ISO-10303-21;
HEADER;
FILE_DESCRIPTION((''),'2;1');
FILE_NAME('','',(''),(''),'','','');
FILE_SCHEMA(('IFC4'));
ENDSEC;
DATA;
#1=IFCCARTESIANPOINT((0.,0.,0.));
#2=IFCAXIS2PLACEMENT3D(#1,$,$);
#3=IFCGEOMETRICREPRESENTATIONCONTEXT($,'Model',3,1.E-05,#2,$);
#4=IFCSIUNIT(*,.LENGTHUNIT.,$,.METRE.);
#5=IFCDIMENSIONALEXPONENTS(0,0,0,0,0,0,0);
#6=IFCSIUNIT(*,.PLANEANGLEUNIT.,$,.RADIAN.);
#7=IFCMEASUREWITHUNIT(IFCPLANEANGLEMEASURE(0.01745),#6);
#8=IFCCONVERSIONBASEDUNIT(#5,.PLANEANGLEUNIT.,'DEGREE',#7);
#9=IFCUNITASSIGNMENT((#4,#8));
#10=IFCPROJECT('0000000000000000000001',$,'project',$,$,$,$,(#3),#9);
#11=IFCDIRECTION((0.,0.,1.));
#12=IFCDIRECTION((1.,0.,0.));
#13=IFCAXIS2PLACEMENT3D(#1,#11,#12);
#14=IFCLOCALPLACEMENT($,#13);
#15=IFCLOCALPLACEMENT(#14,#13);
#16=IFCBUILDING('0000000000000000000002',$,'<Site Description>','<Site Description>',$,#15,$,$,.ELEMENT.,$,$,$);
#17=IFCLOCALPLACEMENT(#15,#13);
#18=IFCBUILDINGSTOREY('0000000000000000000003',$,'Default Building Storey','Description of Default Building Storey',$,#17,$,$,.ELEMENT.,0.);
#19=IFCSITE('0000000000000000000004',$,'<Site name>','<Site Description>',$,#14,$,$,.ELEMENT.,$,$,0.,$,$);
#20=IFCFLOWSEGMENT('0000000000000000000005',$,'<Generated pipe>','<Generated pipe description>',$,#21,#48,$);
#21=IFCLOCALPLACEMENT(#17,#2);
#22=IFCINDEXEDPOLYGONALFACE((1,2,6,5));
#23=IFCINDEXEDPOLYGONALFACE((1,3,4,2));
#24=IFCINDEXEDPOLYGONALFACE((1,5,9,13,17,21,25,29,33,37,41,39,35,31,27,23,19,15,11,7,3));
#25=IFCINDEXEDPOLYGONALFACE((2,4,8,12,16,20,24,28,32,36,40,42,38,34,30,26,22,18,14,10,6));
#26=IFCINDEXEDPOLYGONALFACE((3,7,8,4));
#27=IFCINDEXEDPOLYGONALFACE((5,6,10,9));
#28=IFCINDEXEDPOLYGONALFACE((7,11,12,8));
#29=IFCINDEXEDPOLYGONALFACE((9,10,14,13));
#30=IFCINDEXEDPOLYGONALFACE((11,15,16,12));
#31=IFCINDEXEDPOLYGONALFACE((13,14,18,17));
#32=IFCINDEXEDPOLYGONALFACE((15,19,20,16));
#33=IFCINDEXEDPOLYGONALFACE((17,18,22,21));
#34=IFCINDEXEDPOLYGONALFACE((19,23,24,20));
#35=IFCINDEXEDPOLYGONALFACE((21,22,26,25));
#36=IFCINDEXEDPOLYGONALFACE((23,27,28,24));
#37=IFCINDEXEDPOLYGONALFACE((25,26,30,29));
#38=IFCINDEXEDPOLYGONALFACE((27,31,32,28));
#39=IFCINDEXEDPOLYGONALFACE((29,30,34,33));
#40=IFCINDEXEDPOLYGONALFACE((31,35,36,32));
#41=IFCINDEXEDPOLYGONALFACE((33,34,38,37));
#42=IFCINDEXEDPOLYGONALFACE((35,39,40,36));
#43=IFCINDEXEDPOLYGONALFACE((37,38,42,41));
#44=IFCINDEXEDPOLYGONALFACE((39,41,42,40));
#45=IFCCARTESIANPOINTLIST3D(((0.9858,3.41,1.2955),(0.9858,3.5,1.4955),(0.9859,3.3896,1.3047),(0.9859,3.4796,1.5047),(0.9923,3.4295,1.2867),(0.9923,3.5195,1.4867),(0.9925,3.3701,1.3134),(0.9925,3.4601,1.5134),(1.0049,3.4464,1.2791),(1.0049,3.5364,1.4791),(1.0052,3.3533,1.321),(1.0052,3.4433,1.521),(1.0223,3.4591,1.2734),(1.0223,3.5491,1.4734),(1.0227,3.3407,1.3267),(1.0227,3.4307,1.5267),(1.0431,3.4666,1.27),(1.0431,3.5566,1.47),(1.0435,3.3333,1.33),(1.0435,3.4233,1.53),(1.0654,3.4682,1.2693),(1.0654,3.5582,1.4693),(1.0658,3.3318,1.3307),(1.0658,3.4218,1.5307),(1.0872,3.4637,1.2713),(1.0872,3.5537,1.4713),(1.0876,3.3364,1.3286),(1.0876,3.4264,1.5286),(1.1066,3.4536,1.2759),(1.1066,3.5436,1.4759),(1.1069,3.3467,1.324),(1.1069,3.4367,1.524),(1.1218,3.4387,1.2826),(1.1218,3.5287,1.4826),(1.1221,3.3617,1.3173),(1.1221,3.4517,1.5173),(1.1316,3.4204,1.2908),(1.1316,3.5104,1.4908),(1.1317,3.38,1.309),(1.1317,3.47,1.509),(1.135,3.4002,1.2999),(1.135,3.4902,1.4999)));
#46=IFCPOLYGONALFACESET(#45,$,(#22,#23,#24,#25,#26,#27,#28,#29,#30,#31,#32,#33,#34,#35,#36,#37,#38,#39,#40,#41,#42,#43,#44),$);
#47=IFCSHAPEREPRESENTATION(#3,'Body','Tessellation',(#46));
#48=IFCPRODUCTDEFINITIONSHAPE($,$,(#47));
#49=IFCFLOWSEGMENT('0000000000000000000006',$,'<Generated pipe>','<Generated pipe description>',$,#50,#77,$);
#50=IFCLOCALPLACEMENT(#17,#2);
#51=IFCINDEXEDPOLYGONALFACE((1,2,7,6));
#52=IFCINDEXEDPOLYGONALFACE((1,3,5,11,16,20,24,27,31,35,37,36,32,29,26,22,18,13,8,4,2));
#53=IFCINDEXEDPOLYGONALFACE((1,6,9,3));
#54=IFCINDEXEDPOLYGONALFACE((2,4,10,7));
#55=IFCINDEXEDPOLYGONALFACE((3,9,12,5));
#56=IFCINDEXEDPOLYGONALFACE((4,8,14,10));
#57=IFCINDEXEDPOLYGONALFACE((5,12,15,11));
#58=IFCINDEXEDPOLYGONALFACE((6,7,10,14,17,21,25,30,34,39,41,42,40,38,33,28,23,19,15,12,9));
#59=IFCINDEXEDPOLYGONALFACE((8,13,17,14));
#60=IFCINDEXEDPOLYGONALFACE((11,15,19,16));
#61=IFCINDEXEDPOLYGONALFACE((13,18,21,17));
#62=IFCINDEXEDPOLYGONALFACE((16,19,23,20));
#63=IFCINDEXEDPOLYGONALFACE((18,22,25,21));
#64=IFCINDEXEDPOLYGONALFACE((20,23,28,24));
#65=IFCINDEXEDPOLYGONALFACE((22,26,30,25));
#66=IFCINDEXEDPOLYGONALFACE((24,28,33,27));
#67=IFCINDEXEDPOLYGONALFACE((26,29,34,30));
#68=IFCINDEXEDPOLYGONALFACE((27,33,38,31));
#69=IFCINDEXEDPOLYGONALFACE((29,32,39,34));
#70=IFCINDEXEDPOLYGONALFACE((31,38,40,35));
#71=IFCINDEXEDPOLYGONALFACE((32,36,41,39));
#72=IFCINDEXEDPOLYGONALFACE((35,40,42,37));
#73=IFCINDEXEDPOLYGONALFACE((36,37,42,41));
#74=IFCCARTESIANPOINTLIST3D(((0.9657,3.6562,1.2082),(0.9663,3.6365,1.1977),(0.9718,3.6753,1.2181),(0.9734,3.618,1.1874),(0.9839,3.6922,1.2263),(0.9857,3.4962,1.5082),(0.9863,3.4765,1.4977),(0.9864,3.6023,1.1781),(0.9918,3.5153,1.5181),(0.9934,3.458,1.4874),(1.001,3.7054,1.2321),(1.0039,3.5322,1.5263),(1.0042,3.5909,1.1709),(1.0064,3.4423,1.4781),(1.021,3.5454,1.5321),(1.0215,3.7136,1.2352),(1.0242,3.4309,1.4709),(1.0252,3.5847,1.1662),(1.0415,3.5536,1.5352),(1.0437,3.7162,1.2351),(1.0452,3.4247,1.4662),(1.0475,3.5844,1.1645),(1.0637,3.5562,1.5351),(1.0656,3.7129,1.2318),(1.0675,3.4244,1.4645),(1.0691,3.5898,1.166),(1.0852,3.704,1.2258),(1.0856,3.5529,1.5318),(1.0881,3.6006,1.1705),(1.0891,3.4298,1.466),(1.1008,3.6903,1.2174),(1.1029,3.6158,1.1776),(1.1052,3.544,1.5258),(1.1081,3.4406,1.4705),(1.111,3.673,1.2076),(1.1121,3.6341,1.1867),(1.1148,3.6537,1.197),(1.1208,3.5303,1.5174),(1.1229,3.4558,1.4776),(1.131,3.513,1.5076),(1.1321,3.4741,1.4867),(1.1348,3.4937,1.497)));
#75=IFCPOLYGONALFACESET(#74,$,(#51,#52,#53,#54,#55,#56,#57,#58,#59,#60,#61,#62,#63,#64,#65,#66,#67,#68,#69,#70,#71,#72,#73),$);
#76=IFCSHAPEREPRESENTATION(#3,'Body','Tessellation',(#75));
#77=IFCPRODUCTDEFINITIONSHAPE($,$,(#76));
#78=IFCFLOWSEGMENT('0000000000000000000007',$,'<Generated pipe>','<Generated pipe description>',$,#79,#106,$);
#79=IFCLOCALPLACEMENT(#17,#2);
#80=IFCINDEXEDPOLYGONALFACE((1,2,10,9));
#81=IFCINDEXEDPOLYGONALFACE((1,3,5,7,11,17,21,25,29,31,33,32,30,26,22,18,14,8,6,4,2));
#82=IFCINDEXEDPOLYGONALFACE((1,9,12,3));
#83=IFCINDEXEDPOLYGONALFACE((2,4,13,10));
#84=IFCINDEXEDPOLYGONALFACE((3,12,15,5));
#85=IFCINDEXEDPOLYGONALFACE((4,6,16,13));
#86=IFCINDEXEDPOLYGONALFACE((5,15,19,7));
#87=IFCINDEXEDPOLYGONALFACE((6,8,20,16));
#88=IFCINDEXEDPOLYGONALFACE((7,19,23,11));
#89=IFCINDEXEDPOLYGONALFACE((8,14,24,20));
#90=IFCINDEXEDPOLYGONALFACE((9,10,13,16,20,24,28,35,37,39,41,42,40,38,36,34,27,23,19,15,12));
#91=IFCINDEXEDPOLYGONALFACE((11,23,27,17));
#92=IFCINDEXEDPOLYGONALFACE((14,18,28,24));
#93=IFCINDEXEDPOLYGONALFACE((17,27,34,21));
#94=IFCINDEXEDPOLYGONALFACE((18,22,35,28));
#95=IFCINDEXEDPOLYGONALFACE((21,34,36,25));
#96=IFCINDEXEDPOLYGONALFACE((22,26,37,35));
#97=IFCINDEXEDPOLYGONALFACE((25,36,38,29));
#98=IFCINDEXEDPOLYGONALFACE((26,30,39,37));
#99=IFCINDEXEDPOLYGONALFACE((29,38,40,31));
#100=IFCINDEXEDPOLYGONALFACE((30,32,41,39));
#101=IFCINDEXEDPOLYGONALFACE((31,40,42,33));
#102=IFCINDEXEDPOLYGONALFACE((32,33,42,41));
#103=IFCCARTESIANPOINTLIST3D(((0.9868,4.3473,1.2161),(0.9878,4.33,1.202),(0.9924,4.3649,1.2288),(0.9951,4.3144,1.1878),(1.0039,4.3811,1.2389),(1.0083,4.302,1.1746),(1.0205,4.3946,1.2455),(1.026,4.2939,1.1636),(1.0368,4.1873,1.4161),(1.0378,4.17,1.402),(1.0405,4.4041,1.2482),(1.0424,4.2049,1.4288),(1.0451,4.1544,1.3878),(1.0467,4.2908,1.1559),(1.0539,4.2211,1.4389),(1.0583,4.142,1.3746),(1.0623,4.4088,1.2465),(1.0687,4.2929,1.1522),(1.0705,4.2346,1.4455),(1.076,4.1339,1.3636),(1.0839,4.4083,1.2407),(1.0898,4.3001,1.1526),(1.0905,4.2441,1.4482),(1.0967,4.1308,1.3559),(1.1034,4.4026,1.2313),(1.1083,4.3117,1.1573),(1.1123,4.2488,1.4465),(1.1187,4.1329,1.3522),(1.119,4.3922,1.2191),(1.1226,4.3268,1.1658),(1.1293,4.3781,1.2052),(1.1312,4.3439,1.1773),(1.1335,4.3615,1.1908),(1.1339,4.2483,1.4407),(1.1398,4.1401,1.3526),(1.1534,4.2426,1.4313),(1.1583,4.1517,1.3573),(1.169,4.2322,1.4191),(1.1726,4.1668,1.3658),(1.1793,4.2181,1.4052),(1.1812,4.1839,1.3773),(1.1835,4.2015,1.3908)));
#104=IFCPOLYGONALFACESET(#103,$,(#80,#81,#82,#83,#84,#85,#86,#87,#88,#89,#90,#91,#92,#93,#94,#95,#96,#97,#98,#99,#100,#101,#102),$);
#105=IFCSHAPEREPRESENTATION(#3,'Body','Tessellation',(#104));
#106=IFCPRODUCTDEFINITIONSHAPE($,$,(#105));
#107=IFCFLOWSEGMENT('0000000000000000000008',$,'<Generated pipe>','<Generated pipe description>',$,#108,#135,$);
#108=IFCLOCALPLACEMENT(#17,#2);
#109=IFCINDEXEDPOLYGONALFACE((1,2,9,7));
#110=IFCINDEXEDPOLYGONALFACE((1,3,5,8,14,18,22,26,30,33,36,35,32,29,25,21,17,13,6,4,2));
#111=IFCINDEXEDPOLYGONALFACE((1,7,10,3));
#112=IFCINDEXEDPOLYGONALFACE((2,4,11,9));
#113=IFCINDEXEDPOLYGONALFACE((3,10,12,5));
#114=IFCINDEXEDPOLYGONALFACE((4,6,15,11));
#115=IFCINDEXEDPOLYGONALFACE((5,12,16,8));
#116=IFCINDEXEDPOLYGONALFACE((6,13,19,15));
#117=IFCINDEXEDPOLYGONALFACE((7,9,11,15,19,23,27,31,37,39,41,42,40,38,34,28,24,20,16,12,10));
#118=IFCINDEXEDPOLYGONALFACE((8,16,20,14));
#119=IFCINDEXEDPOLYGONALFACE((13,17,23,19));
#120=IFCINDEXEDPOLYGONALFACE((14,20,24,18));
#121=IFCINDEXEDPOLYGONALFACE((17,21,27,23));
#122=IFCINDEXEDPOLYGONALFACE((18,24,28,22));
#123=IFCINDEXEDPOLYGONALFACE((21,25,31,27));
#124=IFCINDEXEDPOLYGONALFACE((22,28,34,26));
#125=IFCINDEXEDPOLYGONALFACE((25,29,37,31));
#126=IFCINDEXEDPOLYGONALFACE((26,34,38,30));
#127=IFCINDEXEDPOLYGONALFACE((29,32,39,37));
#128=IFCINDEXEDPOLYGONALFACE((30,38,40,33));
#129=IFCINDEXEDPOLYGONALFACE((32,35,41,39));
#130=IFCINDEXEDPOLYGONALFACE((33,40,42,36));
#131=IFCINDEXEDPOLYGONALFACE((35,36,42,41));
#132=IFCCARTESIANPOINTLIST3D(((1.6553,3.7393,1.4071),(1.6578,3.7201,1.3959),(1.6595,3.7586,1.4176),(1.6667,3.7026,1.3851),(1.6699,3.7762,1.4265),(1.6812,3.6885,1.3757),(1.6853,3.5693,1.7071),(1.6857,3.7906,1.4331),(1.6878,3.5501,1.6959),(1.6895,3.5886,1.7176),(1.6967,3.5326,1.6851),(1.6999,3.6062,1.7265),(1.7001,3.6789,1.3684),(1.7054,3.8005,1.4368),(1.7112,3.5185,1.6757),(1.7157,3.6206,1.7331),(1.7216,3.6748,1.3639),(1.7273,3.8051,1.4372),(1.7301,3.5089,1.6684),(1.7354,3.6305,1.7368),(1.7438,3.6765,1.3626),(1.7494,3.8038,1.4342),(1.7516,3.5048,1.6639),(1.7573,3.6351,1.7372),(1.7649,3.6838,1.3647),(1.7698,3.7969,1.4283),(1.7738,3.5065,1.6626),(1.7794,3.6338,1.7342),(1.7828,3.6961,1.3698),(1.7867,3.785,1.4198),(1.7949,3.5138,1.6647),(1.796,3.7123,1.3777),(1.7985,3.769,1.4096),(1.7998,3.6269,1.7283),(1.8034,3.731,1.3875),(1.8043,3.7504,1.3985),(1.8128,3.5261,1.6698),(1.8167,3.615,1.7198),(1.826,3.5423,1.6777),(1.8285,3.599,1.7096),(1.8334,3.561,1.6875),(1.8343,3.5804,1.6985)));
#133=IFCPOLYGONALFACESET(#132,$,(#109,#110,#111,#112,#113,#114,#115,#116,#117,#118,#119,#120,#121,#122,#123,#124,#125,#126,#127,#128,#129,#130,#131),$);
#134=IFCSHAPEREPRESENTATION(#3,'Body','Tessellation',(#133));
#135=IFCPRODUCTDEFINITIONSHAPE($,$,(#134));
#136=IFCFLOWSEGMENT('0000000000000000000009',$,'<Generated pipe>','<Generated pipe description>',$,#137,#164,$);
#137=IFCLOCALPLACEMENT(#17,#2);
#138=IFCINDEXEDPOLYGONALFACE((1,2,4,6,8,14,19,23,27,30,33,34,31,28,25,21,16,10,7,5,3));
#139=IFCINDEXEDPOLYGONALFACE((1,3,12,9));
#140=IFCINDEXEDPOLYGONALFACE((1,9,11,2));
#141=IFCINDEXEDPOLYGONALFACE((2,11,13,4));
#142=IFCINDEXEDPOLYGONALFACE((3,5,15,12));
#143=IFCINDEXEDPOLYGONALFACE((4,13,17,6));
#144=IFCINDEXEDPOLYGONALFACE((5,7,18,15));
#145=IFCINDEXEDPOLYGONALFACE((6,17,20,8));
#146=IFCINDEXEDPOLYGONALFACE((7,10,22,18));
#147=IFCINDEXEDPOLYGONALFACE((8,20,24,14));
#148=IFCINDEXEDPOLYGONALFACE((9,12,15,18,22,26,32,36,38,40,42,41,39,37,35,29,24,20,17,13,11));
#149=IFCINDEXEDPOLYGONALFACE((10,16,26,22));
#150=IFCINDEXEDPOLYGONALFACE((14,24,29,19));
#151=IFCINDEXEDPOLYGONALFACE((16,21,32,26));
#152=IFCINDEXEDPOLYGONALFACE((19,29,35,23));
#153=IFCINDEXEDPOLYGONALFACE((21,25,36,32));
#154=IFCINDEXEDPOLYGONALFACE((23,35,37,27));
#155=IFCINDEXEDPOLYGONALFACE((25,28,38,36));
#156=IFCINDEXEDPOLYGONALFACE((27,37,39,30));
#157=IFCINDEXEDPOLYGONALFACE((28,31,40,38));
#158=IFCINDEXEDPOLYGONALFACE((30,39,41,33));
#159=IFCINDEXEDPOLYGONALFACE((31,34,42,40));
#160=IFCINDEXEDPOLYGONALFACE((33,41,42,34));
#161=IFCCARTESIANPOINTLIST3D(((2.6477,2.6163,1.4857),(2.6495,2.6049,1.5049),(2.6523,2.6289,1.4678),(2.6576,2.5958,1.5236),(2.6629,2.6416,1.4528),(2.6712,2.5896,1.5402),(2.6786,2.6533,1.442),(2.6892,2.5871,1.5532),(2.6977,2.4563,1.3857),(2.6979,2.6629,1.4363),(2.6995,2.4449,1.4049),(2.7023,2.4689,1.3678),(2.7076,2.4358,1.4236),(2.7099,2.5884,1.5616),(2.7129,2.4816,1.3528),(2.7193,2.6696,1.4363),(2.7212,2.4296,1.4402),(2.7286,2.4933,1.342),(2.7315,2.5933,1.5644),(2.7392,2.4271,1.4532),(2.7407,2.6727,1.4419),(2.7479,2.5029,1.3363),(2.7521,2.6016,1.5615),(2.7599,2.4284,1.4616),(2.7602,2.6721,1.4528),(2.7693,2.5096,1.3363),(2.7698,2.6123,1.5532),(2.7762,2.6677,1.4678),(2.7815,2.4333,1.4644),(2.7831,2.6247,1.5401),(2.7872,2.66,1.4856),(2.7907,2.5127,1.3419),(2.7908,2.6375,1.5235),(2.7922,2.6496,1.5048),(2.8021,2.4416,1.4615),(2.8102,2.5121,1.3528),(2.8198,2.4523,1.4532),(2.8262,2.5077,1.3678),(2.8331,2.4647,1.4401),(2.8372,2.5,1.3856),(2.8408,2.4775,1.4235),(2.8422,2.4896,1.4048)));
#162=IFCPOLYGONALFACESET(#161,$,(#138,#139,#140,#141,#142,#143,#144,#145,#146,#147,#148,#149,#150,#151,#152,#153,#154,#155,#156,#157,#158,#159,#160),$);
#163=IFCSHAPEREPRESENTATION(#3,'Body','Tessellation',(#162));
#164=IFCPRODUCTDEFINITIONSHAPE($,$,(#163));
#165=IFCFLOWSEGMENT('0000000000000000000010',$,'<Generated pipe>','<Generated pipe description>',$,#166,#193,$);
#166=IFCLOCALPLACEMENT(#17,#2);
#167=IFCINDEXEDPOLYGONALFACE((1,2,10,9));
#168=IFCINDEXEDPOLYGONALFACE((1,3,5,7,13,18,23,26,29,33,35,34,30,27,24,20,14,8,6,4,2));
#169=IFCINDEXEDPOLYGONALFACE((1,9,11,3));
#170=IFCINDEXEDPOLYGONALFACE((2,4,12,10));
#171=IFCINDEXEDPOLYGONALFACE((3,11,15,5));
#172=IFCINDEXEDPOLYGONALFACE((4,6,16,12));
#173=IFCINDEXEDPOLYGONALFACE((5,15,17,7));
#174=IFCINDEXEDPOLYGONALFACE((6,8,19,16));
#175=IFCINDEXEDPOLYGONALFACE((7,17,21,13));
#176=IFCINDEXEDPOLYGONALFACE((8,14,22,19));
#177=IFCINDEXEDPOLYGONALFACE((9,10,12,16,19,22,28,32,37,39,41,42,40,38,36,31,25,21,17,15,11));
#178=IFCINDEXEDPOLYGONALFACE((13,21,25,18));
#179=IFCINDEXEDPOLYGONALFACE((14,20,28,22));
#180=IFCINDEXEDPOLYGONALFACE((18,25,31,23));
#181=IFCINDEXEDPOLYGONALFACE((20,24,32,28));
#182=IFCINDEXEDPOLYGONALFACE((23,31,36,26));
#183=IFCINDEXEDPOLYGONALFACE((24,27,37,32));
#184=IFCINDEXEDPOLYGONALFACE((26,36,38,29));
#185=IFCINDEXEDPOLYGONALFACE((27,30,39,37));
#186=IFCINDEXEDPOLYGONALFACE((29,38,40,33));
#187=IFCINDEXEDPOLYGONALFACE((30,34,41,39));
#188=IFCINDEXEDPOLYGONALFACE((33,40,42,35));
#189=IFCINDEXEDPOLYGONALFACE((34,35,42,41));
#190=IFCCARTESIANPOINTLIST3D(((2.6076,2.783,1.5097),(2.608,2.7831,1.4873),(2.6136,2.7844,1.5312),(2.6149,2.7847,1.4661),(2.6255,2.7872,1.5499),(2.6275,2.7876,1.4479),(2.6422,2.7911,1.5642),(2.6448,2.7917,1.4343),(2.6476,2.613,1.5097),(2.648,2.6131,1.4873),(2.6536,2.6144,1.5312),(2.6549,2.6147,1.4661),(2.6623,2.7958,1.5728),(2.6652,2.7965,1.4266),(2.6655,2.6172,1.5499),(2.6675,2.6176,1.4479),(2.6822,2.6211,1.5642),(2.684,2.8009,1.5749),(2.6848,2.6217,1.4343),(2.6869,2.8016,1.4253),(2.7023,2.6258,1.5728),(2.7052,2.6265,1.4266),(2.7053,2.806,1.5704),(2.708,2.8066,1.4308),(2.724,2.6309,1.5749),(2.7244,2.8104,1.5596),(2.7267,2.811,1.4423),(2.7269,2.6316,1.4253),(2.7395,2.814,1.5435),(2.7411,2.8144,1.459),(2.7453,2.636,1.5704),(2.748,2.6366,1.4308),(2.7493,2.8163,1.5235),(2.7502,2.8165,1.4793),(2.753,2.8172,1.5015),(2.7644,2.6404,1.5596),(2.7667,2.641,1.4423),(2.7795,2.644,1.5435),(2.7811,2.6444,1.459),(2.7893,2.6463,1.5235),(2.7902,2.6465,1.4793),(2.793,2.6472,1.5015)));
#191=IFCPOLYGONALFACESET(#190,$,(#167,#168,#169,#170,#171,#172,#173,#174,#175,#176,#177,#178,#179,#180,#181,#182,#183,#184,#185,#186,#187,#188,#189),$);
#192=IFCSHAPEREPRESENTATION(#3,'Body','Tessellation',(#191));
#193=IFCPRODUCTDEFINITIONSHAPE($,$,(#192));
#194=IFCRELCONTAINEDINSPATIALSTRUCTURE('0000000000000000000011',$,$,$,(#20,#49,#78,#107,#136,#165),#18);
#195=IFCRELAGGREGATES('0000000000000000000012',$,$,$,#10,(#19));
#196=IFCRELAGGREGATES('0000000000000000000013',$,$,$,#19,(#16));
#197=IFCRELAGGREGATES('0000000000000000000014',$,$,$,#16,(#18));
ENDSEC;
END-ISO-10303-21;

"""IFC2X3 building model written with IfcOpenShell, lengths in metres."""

from ifc_helpers import new_model, entity, si_unit, converted_unit, frame, origin, origin_with_axes, origin_2d_with_axis, place, context, project, spatial, circle, extrude, element, save


model = new_model("IFC2X3")

# Units and contexts
model_context = context("Model", 3, precision=1e-05, world=origin())
ifc_project = project(units=[si_unit("LENGTHUNIT", "METRE"), converted_unit("PLANEANGLEUNIT", "DEGREE", entity("IfcPlaneAngleMeasure", 0.01745), si_unit("PLANEANGLEUNIT", "RADIAN"), dimensions=[0, 0, 0, 0, 0, 0, 0])], contexts=[model_context])

# Site, building, storey
site_placement = place(None, origin_with_axes())
site = spatial("IfcSite", under=ifc_project, at=site_placement, Name="<Site name>", Description="<Site Description>", CompositionType="ELEMENT", RefElevation=0.0)
building_placement = place(site_placement, origin_with_axes())
building = spatial("IfcBuilding", under=site, at=building_placement, Name="<Site Description>", Description="<Site Description>", CompositionType="ELEMENT")
storey_placement = place(building_placement, origin_with_axes())
storey = spatial("IfcBuildingStorey", under=building, at=storey_placement, Name="Default Building Storey", Description="Description of Default Building Storey", CompositionType="ELEMENT", Elevation=0.0)

# Flow segments
flow_segment_1_placement = place(storey_placement, frame((1.06, 3.4, 1.3), z_axis=(0.0, 0.410365, 0.911922), x_axis=(0.82802, -0.511313, 0.230091)))
element("IfcFlowSegment", 1, at=flow_segment_1_placement, inside=storey, Name="<Generated pipe>", Description="<Generated pipe description>", context=model_context, shape_type="SweptSolid", body=[
    extrude(circle(Radius=0.075, at=origin_2d_with_axis()), origin_with_axes(), (0.0, 0.0, 1.0), 0.2193),
])
flow_segment_2_placement = place(storey_placement, frame((1.06, 3.49, 1.5), z_axis=(-0.058722, 0.469776, -0.88083), x_axis=(0.341356, 0.838614, 0.424503)))
element("IfcFlowSegment", 2, at=flow_segment_2_placement, inside=storey, Name="<Generated pipe>", Description="<Generated pipe description>", context=model_context, shape_type="SweptSolid", body=[
    extrude(circle(Radius=0.075, at=origin_2d_with_axis()), origin_with_axes(), (0.0, 0.0, 1.0), 0.3406),
])
flow_segment_3_placement = place(storey_placement, frame((1.11, 4.19, 1.4), z_axis=(-0.1916, 0.613121, -0.766402), x_axis=(0.578159, 0.701512, 0.41667)))
element("IfcFlowSegment", 3, at=flow_segment_3_placement, inside=storey, Name="<Generated pipe>", Description="<Generated pipe description>", context=model_context, shape_type="SweptSolid", body=[
    extrude(circle(Radius=0.075, at=origin_2d_with_axis()), origin_with_axes(), (0.0, 0.0, 1.0), 0.261),
])
flow_segment_4_placement = place(storey_placement, frame((1.73, 3.74, 1.4), z_axis=(0.086675, -0.491157, 0.866748), x_axis=(0.530621, 0.759104, 0.377097)))
element("IfcFlowSegment", 4, at=flow_segment_4_placement, inside=storey, Name="<Generated pipe>", Description="<Generated pipe description>", context=model_context, shape_type="SweptSolid", body=[
    extrude(circle(Radius=0.075, at=origin_2d_with_axis()), origin_with_axes(), (0.0, 0.0, 1.0), 0.3461),
])
flow_segment_5_placement = place(storey_placement, frame((2.77, 2.47, 1.4), z_axis=(-0.256158, 0.819705, 0.512316), x_axis=(0.963169, 0.261287, 0.063525)))
element("IfcFlowSegment", 5, at=flow_segment_5_placement, inside=storey, Name="<Generated pipe>", Description="<Generated pipe description>", context=model_context, shape_type="SweptSolid", body=[
    extrude(circle(Radius=0.075, at=origin_2d_with_axis()), origin_with_axes(), (0.0, 0.0, 1.0), 0.1952),
])
flow_segment_6_placement = place(storey_placement, frame((2.72, 2.63, 1.5), z_axis=(-0.229039, 0.973417, 0.0), x_axis=(0.793059, 0.186602, 0.579859)))
element("IfcFlowSegment", 6, at=flow_segment_6_placement, inside=storey, Name="<Generated pipe>", Description="<Generated pipe description>", context=model_context, shape_type="SweptSolid", body=[
    extrude(circle(Radius=0.075, at=origin_2d_with_axis()), origin_with_axes(), (0.0, 0.0, 1.0), 0.1746),
])

save(model, "model.ifc")
